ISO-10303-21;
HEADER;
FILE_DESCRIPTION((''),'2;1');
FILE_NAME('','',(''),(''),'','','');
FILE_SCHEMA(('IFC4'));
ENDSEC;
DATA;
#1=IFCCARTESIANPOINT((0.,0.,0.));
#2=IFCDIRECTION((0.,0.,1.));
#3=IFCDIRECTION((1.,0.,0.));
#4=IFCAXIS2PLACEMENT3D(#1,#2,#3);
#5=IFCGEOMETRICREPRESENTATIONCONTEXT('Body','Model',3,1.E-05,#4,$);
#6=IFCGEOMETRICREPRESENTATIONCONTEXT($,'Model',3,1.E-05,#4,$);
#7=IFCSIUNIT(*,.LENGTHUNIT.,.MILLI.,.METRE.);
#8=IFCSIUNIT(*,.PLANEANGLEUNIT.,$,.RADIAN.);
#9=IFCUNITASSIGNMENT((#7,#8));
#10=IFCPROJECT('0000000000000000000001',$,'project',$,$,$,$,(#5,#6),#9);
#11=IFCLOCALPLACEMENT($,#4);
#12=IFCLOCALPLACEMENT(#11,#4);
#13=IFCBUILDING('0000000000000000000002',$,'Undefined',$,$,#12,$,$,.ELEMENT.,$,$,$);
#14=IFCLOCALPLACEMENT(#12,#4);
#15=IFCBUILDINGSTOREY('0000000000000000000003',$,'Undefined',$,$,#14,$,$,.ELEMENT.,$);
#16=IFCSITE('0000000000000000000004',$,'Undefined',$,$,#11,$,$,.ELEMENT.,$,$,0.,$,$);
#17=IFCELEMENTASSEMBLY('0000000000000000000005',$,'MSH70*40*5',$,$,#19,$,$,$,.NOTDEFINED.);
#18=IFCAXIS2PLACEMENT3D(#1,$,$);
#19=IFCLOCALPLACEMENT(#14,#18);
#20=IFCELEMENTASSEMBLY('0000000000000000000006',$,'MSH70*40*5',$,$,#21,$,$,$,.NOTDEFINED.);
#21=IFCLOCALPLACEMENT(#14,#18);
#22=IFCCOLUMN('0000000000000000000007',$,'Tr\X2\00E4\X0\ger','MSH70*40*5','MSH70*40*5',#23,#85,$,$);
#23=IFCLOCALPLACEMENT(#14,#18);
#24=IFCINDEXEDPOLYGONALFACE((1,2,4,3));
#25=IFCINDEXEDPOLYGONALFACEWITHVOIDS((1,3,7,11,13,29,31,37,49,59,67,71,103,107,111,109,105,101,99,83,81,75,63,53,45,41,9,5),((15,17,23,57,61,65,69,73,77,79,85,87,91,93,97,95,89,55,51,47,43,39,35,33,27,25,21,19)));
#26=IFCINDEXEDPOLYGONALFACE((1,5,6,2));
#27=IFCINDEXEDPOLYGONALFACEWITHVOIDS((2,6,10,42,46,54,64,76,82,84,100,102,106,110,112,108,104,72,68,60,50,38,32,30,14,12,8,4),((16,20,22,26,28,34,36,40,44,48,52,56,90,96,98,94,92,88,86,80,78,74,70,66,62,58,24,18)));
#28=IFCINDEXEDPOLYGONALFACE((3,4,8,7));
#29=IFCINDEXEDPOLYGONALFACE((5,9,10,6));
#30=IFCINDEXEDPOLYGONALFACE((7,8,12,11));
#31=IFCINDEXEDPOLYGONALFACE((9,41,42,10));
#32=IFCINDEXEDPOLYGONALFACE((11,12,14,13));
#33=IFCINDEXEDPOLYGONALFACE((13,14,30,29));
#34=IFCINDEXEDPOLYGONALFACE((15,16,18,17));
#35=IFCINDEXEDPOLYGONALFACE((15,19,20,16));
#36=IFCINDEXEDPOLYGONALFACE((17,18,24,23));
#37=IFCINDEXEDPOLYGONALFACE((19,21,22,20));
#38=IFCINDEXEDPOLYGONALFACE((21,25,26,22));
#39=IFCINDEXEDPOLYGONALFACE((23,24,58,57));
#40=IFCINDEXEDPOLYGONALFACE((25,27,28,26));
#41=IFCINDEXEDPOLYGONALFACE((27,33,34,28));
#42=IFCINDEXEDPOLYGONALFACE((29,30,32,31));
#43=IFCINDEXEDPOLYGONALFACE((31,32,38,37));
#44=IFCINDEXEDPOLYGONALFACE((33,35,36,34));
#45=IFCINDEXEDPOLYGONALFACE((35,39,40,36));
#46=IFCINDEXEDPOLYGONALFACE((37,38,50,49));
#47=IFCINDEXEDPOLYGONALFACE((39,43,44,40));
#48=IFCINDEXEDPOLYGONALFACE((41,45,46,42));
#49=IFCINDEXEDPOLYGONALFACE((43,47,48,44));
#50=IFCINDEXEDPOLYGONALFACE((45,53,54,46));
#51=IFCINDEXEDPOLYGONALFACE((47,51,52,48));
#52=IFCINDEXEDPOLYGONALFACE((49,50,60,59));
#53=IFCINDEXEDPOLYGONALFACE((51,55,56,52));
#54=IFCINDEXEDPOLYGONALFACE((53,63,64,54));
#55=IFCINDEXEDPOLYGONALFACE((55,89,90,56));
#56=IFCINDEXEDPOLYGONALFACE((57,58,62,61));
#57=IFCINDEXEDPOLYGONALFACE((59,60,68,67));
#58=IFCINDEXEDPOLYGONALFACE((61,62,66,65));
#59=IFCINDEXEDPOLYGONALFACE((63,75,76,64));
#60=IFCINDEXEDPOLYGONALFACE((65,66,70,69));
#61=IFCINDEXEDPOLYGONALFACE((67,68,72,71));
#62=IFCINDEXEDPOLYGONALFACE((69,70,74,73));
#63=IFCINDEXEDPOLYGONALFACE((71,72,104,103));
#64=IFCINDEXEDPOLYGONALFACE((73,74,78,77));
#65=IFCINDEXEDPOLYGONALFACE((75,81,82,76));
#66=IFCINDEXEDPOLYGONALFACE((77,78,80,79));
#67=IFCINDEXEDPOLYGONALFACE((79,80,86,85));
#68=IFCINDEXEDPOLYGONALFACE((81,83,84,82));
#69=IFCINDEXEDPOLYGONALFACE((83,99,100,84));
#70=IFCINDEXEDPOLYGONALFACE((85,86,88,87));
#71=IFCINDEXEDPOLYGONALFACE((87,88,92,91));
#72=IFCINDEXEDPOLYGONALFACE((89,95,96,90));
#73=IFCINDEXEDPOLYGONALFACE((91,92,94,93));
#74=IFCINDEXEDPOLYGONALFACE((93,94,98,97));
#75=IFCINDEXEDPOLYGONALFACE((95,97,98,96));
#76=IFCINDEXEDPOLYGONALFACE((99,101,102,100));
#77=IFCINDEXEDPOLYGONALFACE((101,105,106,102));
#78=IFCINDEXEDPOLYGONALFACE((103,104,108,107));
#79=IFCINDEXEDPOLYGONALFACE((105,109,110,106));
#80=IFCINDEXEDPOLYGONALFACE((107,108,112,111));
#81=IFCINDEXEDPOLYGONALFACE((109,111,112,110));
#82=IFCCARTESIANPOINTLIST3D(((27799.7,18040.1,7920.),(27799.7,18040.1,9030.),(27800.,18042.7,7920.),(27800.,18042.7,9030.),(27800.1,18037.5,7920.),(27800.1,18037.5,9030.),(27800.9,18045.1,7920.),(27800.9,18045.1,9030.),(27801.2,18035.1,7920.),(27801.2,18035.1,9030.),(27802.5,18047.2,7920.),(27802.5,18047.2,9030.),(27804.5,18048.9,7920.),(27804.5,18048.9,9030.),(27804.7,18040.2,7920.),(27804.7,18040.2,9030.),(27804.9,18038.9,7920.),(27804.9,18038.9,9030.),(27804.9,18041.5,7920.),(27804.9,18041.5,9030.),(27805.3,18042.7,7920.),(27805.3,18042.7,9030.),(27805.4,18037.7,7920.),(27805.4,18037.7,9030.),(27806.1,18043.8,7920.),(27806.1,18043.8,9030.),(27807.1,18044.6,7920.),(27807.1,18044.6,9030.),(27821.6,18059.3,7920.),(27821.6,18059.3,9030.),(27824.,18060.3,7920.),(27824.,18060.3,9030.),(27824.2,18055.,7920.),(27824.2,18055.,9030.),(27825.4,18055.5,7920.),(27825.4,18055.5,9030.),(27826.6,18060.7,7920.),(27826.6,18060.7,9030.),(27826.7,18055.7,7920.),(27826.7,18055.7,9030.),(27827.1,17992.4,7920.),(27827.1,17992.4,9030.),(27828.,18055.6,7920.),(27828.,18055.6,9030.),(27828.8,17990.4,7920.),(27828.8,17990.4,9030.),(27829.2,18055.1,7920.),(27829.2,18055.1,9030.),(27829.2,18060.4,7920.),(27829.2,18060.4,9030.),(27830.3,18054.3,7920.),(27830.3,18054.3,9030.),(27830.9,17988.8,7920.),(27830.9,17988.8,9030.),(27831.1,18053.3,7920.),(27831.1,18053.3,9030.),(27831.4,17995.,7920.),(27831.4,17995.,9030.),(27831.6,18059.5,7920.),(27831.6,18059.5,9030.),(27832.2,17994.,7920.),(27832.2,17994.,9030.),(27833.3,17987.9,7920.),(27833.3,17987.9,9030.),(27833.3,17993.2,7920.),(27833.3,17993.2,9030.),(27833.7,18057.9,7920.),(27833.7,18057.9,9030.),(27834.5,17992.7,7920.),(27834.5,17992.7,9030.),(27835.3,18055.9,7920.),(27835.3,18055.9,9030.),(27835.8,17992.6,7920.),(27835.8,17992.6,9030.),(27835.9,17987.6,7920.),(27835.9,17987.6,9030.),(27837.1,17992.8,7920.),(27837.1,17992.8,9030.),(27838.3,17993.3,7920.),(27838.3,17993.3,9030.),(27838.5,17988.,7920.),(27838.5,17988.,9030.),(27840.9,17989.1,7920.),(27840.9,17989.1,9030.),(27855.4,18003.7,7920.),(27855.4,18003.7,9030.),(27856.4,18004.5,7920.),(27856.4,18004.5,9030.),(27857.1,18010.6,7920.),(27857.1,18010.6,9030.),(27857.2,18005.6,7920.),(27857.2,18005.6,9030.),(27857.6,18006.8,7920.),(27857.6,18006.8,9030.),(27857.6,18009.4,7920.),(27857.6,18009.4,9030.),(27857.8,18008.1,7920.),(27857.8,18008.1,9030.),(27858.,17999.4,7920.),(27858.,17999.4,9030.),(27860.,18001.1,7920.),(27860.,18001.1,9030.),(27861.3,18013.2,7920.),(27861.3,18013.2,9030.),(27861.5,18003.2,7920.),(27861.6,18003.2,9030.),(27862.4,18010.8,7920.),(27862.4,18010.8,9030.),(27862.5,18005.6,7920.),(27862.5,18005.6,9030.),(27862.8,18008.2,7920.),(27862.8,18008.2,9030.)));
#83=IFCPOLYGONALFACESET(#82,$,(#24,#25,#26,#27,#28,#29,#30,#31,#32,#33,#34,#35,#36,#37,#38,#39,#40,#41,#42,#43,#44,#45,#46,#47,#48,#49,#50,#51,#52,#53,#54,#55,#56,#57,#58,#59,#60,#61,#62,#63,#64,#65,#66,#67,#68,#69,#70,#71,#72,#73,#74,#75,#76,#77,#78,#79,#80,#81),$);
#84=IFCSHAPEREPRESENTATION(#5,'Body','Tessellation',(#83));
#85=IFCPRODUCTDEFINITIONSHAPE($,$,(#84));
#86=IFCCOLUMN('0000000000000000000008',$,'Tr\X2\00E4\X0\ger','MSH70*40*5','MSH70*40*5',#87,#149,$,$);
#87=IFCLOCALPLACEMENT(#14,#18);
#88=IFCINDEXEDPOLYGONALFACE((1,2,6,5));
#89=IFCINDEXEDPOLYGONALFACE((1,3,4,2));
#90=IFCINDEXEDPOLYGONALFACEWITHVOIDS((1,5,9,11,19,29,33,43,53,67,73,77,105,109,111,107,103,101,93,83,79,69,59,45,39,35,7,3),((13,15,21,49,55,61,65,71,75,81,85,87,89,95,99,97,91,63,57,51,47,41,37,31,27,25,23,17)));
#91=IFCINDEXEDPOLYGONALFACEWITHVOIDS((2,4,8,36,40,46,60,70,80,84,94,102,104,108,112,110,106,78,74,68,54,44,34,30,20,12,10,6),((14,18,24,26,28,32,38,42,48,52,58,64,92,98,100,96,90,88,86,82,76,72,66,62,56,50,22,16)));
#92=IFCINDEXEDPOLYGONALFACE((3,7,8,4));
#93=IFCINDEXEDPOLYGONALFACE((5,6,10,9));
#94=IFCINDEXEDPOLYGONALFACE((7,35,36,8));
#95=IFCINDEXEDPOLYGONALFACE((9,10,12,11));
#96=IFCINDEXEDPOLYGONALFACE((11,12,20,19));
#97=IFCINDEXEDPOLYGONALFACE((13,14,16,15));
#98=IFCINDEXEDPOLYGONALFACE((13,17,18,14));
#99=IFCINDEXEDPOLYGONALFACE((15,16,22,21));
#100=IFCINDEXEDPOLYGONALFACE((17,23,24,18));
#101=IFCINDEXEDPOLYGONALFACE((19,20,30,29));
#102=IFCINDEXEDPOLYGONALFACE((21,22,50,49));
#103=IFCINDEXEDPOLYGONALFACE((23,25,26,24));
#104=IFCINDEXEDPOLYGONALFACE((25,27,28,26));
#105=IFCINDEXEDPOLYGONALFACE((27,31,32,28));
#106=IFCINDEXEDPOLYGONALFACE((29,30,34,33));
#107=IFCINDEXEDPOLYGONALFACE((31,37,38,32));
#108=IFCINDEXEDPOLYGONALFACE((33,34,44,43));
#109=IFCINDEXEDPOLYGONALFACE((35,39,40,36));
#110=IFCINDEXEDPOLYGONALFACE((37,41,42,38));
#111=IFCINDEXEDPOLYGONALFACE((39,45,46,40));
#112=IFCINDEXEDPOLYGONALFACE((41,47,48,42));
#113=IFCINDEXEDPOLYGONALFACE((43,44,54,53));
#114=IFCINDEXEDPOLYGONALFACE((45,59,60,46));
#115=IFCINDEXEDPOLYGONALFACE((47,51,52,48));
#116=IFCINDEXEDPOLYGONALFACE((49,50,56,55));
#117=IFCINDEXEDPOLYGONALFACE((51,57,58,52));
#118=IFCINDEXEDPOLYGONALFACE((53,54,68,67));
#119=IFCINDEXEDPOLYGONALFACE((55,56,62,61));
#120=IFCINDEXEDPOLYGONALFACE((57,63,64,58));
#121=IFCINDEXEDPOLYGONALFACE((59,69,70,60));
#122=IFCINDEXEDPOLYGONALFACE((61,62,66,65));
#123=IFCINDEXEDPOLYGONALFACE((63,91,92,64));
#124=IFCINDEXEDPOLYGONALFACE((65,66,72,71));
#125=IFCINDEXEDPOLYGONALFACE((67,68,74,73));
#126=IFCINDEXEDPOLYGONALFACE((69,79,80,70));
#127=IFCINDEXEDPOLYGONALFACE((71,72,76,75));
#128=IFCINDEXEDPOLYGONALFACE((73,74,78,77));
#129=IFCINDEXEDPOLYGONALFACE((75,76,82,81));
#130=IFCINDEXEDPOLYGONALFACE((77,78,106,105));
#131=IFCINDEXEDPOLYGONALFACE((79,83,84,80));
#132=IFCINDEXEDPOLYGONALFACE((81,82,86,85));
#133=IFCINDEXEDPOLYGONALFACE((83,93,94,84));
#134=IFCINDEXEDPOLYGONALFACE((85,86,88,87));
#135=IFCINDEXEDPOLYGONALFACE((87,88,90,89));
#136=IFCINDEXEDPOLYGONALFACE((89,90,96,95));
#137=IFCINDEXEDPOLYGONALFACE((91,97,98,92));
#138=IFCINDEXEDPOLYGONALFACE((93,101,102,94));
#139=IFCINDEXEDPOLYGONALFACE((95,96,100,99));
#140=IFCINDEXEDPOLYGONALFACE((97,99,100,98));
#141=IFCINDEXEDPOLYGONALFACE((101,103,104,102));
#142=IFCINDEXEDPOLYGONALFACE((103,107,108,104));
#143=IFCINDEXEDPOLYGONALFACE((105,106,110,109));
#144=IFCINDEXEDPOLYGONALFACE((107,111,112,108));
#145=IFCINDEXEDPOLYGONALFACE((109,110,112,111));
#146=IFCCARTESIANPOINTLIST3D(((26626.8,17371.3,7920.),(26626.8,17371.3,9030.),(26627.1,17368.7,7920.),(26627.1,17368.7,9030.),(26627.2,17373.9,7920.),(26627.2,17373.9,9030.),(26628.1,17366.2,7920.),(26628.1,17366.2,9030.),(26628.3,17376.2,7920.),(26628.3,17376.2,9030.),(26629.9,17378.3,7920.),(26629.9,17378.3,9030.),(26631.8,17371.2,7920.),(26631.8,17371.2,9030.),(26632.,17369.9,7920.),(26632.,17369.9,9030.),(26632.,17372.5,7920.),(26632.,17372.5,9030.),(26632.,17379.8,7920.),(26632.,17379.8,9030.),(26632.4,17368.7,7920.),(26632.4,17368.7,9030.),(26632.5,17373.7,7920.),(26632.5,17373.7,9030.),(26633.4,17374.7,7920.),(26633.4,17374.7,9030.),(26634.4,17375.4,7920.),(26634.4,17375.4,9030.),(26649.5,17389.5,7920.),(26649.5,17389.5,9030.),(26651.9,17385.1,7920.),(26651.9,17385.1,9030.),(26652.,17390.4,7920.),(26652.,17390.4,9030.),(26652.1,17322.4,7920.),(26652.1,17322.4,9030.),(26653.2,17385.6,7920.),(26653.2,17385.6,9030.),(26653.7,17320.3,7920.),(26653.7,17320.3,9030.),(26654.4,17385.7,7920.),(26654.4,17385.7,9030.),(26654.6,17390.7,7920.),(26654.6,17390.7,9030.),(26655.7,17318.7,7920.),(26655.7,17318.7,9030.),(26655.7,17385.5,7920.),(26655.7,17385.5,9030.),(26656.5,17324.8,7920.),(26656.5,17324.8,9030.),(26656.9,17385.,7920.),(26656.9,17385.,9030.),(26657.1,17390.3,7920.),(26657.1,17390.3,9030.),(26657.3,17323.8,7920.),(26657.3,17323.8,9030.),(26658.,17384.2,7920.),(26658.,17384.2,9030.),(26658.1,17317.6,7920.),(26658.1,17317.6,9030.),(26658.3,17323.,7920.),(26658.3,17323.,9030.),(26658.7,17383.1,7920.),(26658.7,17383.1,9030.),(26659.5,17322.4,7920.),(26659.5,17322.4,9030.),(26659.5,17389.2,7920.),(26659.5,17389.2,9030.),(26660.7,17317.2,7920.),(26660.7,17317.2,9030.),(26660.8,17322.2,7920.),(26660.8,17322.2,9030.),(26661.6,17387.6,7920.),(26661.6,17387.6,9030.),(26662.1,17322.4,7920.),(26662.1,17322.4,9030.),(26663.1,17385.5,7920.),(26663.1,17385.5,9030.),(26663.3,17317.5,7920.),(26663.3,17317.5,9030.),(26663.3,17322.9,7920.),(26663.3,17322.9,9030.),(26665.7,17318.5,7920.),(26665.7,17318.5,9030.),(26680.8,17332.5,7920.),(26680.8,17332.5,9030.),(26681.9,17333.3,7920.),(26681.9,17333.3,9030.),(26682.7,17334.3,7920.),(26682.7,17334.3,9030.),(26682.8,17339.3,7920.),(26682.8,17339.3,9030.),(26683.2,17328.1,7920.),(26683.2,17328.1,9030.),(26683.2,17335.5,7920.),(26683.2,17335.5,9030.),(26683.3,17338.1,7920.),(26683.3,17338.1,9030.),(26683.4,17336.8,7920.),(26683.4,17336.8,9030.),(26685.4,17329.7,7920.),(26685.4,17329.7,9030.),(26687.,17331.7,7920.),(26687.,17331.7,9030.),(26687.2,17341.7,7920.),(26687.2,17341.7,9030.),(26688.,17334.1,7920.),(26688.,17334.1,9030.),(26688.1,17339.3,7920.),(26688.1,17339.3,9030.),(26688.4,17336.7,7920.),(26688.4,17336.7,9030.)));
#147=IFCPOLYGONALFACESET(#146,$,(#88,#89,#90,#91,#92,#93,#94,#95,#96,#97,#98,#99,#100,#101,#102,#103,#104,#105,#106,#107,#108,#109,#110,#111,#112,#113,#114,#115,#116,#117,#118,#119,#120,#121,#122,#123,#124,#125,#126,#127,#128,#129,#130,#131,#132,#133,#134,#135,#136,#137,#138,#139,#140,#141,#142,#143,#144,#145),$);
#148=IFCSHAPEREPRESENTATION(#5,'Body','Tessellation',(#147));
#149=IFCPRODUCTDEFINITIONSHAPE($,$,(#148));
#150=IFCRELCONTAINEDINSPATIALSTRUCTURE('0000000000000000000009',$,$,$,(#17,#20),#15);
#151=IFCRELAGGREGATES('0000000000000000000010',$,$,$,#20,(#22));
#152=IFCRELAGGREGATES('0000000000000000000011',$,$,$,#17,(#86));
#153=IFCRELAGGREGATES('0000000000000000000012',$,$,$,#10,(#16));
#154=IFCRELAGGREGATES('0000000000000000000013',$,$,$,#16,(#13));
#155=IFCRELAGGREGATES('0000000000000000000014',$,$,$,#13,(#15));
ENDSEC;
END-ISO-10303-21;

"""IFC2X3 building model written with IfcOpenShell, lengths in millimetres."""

from ifc_helpers import new_model, si_unit, frame, origin_with_axes, origin_2d_with_axis, place, context, project, spatial, hollow_rectangle, extrude, element, aggregate, save


model = new_model("IFC2X3")

# Units and contexts
model_context_1 = context("Model", 3, precision=1e-05, world=origin_with_axes(), identifier="Body")
model_context_2 = context("Model", 3, precision=1e-05, world=origin_with_axes())
ifc_project = project(units=[si_unit("LENGTHUNIT", "METRE", prefix="MILLI"), si_unit("PLANEANGLEUNIT", "RADIAN")], contexts=[model_context_1, model_context_2])

# Site, building, storey
site_placement = place(None, origin_with_axes())
site = spatial("IfcSite", under=ifc_project, at=site_placement, Name="Undefined", CompositionType="ELEMENT", RefElevation=0.0)
building_placement = place(site_placement, origin_with_axes())
building = spatial("IfcBuilding", under=site, at=building_placement, Name="Undefined", CompositionType="ELEMENT")
storey_placement = place(building_placement, origin_with_axes())
storey = spatial("IfcBuildingStorey", under=building, at=storey_placement, Name="Undefined", CompositionType="ELEMENT")

# Element assembly
assembly_1 = element("IfcElementAssembly", 1, inside=storey, Name="MSH70*40*5", PredefinedType="NOTDEFINED")

# Element assembly
assembly_2 = element("IfcElementAssembly", 2, inside=storey, Name="MSH70*40*5", PredefinedType="NOTDEFINED")

# Columns
column_1_placement = place(storey_placement, frame((27831.2, 18024.2, 7920.0), z_axis=(0.0, 0.0, 1.0), x_axis=(1.0, 0.0, 0.0)))
column_1 = element("IfcColumn", 3, at=column_1_placement, Name="Träger", Description="MSH70*40*5", ObjectType="MSH70*40*5", context=model_context_1, shape_type="SweptSolid", body=[
    extrude(hollow_rectangle(XDim=40.0, YDim=70.0, WallThickness=5.0, InnerFilletRadius=5.0, OuterFilletRadius=10.0, at=origin_2d_with_axis()), frame((0.0, 0.0, 1110.0), z_axis=(0.0, 0.0, -1.0), x_axis=(-0.854459, -0.51952, 0.000005)), (0.0, 0.0, 1.0), 1110.0),
])
aggregate(assembly_2, [column_1])
column_2_placement = place(storey_placement, frame((26657.6, 17354.0, 7920.0), z_axis=(0.0, 0.0, 1.0), x_axis=(1.0, 0.0, 0.0)))
column_2 = element("IfcColumn", 4, at=column_2_placement, Name="Träger", Description="MSH70*40*5", ObjectType="MSH70*40*5", context=model_context_1, shape_type="SweptSolid", body=[
    extrude(hollow_rectangle(XDim=40.0, YDim=70.0, WallThickness=5.0, InnerFilletRadius=5.0, OuterFilletRadius=10.0, at=origin_2d_with_axis()), frame((0.0, 0.0, 1110.0), z_axis=(0.0, 0.0, -1.0), x_axis=(-0.876306, -0.481754, 0.000005)), (0.0, 0.0, 1.0), 1110.0),
])
aggregate(assembly_1, [column_2])

save(model, "model.ifc")
